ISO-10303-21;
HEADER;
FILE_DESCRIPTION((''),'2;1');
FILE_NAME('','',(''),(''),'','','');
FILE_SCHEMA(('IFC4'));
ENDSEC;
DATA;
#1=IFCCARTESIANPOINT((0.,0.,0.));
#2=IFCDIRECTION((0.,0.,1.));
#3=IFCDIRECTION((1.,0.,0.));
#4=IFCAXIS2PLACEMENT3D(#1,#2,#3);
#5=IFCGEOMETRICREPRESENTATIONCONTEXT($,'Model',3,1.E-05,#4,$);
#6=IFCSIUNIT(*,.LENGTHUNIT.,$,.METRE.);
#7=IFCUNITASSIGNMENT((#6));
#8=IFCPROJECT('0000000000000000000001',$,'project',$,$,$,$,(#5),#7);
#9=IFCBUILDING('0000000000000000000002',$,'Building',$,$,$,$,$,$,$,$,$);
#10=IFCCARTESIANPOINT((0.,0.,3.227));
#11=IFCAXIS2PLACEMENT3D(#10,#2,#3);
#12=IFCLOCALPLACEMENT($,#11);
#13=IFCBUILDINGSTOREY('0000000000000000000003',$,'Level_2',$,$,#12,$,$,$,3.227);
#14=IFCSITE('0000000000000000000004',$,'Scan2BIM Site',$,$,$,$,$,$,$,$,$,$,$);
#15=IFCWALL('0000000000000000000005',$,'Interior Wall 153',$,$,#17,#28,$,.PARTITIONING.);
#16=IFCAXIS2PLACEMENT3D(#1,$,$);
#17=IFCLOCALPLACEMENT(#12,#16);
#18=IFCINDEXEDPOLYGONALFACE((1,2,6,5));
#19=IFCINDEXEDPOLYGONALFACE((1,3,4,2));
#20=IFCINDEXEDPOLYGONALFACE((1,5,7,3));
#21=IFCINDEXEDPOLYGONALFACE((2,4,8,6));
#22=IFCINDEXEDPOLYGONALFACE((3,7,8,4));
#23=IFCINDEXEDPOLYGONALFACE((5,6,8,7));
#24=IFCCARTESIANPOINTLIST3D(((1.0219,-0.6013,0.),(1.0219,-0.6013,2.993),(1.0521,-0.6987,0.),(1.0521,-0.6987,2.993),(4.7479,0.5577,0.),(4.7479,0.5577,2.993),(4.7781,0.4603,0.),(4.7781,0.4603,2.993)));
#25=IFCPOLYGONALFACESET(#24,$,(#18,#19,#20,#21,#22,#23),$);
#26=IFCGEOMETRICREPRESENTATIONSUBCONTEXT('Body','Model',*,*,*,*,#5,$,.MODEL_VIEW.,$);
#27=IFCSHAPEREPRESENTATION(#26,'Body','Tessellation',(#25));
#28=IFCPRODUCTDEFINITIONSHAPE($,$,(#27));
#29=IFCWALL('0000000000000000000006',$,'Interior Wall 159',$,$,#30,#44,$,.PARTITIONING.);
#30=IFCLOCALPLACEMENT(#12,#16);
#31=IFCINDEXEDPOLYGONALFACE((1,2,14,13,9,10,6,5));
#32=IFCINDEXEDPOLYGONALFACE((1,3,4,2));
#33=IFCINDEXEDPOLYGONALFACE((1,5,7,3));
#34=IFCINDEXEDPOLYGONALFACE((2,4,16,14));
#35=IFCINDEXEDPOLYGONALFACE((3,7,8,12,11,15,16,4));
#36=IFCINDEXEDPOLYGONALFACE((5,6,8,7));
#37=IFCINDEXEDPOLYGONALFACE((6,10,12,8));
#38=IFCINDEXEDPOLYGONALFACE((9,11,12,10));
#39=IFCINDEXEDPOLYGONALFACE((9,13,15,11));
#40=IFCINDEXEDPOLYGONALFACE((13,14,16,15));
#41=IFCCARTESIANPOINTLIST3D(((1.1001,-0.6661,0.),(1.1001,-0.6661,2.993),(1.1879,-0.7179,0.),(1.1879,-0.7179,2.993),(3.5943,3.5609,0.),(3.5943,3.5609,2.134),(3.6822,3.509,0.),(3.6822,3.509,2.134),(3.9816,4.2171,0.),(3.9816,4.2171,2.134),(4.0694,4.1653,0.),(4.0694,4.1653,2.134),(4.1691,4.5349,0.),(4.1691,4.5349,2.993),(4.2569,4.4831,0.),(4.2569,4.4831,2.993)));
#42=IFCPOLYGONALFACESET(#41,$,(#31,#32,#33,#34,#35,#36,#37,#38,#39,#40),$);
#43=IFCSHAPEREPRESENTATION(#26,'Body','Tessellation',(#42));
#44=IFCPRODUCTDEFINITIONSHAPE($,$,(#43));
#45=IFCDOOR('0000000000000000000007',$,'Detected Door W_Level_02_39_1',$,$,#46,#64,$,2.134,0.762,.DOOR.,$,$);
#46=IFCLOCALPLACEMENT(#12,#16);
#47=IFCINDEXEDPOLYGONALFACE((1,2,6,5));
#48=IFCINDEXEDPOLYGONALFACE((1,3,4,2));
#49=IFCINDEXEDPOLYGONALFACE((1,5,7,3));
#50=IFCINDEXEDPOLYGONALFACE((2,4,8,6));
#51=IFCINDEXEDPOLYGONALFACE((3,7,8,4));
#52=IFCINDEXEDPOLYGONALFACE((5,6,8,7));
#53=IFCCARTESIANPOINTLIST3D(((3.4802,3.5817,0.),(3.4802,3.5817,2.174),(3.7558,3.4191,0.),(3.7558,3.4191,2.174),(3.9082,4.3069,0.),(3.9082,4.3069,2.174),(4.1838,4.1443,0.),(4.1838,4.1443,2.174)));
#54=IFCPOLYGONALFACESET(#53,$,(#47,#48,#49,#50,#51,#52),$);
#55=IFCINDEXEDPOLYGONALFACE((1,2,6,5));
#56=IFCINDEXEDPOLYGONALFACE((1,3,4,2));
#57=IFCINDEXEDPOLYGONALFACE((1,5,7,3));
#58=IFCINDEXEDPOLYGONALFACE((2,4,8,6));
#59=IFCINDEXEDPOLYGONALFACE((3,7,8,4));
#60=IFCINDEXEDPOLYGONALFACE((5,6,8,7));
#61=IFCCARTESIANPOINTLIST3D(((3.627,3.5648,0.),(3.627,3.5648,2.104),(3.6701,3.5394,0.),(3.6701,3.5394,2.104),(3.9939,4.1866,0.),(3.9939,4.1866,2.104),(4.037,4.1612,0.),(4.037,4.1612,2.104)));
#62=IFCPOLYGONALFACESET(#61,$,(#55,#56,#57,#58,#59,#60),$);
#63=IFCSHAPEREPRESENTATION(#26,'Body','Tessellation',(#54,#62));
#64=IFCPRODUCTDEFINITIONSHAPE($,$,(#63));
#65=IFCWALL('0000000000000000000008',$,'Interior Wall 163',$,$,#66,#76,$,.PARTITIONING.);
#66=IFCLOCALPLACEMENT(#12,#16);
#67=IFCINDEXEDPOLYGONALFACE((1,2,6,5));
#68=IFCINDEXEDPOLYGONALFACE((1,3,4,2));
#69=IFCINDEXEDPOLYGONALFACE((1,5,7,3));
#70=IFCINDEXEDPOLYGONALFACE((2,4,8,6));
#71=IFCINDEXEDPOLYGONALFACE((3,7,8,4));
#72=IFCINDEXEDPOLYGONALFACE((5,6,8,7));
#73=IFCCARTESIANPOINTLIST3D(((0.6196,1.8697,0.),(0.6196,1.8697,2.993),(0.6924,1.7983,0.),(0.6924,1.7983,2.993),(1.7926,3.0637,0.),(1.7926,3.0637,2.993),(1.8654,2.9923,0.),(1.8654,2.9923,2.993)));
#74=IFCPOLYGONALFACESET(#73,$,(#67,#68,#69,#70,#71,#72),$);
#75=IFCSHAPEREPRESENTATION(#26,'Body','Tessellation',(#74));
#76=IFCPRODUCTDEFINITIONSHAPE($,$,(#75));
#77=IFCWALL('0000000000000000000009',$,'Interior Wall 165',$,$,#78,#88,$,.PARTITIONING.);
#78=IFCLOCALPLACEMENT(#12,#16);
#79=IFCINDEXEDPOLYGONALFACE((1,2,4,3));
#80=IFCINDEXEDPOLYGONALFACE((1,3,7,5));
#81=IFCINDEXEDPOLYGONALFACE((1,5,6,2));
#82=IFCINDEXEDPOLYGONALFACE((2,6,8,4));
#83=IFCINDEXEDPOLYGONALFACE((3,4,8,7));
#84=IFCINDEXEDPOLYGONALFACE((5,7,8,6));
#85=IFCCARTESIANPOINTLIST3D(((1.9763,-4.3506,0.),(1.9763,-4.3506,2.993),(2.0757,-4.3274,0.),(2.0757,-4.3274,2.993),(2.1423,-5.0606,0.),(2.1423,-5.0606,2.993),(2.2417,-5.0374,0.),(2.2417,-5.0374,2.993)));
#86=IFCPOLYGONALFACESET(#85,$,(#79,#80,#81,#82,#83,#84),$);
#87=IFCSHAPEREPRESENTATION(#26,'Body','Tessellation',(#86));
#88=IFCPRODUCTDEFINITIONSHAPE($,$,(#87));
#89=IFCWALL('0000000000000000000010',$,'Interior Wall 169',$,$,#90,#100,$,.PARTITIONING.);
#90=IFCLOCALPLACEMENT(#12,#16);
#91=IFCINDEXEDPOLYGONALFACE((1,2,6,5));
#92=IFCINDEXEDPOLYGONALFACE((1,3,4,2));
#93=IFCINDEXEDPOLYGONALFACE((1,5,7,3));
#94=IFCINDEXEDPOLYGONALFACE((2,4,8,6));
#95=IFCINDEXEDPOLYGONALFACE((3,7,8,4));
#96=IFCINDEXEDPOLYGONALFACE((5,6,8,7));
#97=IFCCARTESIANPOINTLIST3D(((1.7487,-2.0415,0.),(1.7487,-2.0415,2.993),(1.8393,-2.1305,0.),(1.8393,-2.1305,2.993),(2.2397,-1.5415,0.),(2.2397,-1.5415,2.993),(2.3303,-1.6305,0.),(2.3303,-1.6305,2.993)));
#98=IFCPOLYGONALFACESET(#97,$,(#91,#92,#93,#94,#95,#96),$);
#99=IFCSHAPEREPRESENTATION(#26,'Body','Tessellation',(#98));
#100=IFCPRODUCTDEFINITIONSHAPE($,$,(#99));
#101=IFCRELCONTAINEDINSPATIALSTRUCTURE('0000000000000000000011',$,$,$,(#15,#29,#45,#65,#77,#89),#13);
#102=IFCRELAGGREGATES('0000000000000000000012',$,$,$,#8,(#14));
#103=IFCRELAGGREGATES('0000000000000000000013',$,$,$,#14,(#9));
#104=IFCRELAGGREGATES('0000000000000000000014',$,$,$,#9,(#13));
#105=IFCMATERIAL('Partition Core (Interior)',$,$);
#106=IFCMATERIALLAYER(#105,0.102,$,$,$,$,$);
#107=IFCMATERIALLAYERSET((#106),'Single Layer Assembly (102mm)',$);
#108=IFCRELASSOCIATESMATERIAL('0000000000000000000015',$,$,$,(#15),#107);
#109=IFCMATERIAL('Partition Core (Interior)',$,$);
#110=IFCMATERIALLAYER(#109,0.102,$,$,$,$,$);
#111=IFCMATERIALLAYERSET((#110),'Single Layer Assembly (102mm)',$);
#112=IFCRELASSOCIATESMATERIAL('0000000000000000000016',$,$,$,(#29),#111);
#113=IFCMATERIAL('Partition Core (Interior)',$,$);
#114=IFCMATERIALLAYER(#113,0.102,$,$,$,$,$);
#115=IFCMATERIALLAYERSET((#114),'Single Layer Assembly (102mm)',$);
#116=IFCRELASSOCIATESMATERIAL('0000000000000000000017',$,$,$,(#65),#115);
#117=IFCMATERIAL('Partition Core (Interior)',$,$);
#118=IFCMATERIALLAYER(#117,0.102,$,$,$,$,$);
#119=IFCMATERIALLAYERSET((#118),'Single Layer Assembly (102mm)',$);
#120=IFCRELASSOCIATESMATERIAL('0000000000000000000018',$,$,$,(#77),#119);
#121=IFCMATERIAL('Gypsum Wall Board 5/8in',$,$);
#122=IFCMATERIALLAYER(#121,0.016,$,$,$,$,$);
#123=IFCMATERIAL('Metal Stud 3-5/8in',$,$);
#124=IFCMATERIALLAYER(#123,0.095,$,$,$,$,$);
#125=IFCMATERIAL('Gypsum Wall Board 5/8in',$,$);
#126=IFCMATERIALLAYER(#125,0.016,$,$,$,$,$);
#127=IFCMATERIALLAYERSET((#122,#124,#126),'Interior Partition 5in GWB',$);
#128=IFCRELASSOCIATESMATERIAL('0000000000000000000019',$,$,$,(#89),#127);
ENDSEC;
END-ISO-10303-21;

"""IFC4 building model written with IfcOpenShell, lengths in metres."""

from ifc_helpers import new_model, si_unit, frame, origin, origin_with_axes, place, context, subcontext, project, spatial, rectangle, extrude, material, layer, layer_set, element, fill, save


model = new_model("IFC4")

# Units and contexts
model_context = context("Model", 3, precision=1e-05, world=origin_with_axes())
body_context = subcontext(model_context, "Body", "Model", "MODEL_VIEW")
ifc_project = project(units=[si_unit("LENGTHUNIT", "METRE")], contexts=[model_context])

# Site, building, storey
site = spatial("IfcSite", under=ifc_project, Name="Scan2BIM Site")
building = spatial("IfcBuilding", under=site, Name="Building")
storey_placement = place(None, frame((0.0, 0.0, 3.227), z_axis=(0.0, 0.0, 1.0), x_axis=(1.0, 0.0, 0.0)))
storey = spatial("IfcBuildingStorey", under=building, at=storey_placement, Name="Level_2", Elevation=3.227)

# Wall
ifc_material_1 = material(Name="Partition Core (Interior)")
ifc_layer_1 = layer(ifc_material_1, 0.102)
ifc_layer_set_1 = layer_set([ifc_layer_1], Name="Single Layer Assembly (102mm)")
wall_1_placement = place(storey_placement, frame((2.9, -0.0705, 0.0), z_axis=(0.0, 0.0, 1.0), x_axis=(0.954871, 0.29702, 0.0)))
element("IfcWall", 1, at=wall_1_placement, inside=storey, material=ifc_layer_set_1, Name="Interior Wall 153", PredefinedType="PARTITIONING", context=body_context, shape_type="SweptSolid", body=[
    extrude(rectangle(XDim=3.9021, YDim=0.102), origin(), (0.0, 0.0, 1.0), 2.993),
])

# Wall, opening, door
ifc_material_2 = material(Name="Partition Core (Interior)")
ifc_layer_2 = layer(ifc_material_2, 0.102)
ifc_layer_set_2 = layer_set([ifc_layer_2], Name="Single Layer Assembly (102mm)")
wall_2_placement = place(storey_placement, frame((2.6785, 1.9085, 0.0), z_axis=(0.0, 0.0, 1.0), x_axis=(-0.508199, -0.86124, 0.0)))
wall_2 = element("IfcWall", 2, at=wall_2_placement, inside=storey, material=ifc_layer_set_2, Name="Interior Wall 159", PredefinedType="PARTITIONING", context=body_context, shape_type="SweptSolid", body=[
    extrude(rectangle(XDim=6.039, YDim=0.102), origin(), (0.0, 0.0, 1.0), 2.993),
])
opening_1_placement = place(None, frame((3.832, 3.863, 3.227), z_axis=(0.0, 0.0, 1.0), x_axis=(-0.508199, -0.86124, 0.0)))
opening_1 = element("IfcOpeningElement", 3, at=opening_1_placement, cuts=wall_2, PredefinedType="OPENING", context=body_context, shape_type="SweptSolid", body=[
    extrude(rectangle(XDim=0.762, YDim=0.202), origin(), (0.0, 0.0, 1.0), 2.134),
])
door_1_placement = place(opening_1_placement, frame((0.0, 0.0, 0.0), z_axis=(0.0, 0.0, 1.0), x_axis=(1.0, 0.0, 0.0)))
door_1 = element("IfcDoor", 4, at=door_1_placement, inside=storey, Name="Detected Door W_Level_02_39_1", OverallHeight=2.134, OverallWidth=0.762, PredefinedType="DOOR", context=body_context, shape_type="SweptSolid", body=[
    extrude(rectangle(XDim=0.842, YDim=0.32), origin(), (0.0, 0.0, 1.0), 2.174),
    extrude(rectangle(XDim=0.722, YDim=0.05), origin(), (0.0, 0.0, 1.0), 2.104),
])
fill(opening_1, door_1)

# Walls
ifc_material_3 = material(Name="Partition Core (Interior)")
ifc_layer_3 = layer(ifc_material_3, 0.102)
ifc_layer_set_3 = layer_set([ifc_layer_3], Name="Single Layer Assembly (102mm)")
wall_3_placement = place(storey_placement, frame((1.2425, 2.431, 0.0), z_axis=(0.0, 0.0, 1.0), x_axis=(0.700806, 0.713352, 0.0)))
element("IfcWall", 5, at=wall_3_placement, inside=storey, material=ifc_layer_set_3, Name="Interior Wall 163", PredefinedType="PARTITIONING", context=body_context, shape_type="SweptSolid", body=[
    extrude(rectangle(XDim=1.6738, YDim=0.102), origin(), (0.0, 0.0, 1.0), 2.993),
])
ifc_material_4 = material(Name="Partition Core (Interior)")
ifc_layer_4 = layer(ifc_material_4, 0.102)
ifc_layer_set_4 = layer_set([ifc_layer_4], Name="Single Layer Assembly (102mm)")
wall_4_placement = place(storey_placement, frame((2.109, -4.694, 0.0), z_axis=(0.0, 0.0, 1.0), x_axis=(0.227663, -0.97374, 0.0)))
element("IfcWall", 6, at=wall_4_placement, inside=storey, material=ifc_layer_set_4, Name="Interior Wall 165", PredefinedType="PARTITIONING", context=body_context, shape_type="SweptSolid", body=[
    extrude(rectangle(XDim=0.7291, YDim=0.102), origin(), (0.0, 0.0, 1.0), 2.993),
])
ifc_material_5 = material(Name="Gypsum Wall Board 5/8in")
ifc_layer_5 = layer(ifc_material_5, 0.016)
ifc_material_6 = material(Name="Metal Stud 3-5/8in")
ifc_layer_6 = layer(ifc_material_6, 0.095)
ifc_material_7 = material(Name="Gypsum Wall Board 5/8in")
ifc_layer_7 = layer(ifc_material_7, 0.016)
ifc_layer_set_5 = layer_set([ifc_layer_5, ifc_layer_6, ifc_layer_7], Name="Interior Partition 5in GWB")
wall_5_placement = place(storey_placement, frame((2.0395, -1.836, 0.0), z_axis=(0.0, 0.0, 1.0), x_axis=(0.700656, 0.713499, 0.0)))
element("IfcWall", 7, at=wall_5_placement, inside=storey, material=ifc_layer_set_5, Name="Interior Wall 169", PredefinedType="PARTITIONING", context=body_context, shape_type="SweptSolid", body=[
    extrude(rectangle(XDim=0.7008, YDim=0.127), origin(), (0.0, 0.0, 1.0), 2.993),
])

save(model, "model.ifc")
